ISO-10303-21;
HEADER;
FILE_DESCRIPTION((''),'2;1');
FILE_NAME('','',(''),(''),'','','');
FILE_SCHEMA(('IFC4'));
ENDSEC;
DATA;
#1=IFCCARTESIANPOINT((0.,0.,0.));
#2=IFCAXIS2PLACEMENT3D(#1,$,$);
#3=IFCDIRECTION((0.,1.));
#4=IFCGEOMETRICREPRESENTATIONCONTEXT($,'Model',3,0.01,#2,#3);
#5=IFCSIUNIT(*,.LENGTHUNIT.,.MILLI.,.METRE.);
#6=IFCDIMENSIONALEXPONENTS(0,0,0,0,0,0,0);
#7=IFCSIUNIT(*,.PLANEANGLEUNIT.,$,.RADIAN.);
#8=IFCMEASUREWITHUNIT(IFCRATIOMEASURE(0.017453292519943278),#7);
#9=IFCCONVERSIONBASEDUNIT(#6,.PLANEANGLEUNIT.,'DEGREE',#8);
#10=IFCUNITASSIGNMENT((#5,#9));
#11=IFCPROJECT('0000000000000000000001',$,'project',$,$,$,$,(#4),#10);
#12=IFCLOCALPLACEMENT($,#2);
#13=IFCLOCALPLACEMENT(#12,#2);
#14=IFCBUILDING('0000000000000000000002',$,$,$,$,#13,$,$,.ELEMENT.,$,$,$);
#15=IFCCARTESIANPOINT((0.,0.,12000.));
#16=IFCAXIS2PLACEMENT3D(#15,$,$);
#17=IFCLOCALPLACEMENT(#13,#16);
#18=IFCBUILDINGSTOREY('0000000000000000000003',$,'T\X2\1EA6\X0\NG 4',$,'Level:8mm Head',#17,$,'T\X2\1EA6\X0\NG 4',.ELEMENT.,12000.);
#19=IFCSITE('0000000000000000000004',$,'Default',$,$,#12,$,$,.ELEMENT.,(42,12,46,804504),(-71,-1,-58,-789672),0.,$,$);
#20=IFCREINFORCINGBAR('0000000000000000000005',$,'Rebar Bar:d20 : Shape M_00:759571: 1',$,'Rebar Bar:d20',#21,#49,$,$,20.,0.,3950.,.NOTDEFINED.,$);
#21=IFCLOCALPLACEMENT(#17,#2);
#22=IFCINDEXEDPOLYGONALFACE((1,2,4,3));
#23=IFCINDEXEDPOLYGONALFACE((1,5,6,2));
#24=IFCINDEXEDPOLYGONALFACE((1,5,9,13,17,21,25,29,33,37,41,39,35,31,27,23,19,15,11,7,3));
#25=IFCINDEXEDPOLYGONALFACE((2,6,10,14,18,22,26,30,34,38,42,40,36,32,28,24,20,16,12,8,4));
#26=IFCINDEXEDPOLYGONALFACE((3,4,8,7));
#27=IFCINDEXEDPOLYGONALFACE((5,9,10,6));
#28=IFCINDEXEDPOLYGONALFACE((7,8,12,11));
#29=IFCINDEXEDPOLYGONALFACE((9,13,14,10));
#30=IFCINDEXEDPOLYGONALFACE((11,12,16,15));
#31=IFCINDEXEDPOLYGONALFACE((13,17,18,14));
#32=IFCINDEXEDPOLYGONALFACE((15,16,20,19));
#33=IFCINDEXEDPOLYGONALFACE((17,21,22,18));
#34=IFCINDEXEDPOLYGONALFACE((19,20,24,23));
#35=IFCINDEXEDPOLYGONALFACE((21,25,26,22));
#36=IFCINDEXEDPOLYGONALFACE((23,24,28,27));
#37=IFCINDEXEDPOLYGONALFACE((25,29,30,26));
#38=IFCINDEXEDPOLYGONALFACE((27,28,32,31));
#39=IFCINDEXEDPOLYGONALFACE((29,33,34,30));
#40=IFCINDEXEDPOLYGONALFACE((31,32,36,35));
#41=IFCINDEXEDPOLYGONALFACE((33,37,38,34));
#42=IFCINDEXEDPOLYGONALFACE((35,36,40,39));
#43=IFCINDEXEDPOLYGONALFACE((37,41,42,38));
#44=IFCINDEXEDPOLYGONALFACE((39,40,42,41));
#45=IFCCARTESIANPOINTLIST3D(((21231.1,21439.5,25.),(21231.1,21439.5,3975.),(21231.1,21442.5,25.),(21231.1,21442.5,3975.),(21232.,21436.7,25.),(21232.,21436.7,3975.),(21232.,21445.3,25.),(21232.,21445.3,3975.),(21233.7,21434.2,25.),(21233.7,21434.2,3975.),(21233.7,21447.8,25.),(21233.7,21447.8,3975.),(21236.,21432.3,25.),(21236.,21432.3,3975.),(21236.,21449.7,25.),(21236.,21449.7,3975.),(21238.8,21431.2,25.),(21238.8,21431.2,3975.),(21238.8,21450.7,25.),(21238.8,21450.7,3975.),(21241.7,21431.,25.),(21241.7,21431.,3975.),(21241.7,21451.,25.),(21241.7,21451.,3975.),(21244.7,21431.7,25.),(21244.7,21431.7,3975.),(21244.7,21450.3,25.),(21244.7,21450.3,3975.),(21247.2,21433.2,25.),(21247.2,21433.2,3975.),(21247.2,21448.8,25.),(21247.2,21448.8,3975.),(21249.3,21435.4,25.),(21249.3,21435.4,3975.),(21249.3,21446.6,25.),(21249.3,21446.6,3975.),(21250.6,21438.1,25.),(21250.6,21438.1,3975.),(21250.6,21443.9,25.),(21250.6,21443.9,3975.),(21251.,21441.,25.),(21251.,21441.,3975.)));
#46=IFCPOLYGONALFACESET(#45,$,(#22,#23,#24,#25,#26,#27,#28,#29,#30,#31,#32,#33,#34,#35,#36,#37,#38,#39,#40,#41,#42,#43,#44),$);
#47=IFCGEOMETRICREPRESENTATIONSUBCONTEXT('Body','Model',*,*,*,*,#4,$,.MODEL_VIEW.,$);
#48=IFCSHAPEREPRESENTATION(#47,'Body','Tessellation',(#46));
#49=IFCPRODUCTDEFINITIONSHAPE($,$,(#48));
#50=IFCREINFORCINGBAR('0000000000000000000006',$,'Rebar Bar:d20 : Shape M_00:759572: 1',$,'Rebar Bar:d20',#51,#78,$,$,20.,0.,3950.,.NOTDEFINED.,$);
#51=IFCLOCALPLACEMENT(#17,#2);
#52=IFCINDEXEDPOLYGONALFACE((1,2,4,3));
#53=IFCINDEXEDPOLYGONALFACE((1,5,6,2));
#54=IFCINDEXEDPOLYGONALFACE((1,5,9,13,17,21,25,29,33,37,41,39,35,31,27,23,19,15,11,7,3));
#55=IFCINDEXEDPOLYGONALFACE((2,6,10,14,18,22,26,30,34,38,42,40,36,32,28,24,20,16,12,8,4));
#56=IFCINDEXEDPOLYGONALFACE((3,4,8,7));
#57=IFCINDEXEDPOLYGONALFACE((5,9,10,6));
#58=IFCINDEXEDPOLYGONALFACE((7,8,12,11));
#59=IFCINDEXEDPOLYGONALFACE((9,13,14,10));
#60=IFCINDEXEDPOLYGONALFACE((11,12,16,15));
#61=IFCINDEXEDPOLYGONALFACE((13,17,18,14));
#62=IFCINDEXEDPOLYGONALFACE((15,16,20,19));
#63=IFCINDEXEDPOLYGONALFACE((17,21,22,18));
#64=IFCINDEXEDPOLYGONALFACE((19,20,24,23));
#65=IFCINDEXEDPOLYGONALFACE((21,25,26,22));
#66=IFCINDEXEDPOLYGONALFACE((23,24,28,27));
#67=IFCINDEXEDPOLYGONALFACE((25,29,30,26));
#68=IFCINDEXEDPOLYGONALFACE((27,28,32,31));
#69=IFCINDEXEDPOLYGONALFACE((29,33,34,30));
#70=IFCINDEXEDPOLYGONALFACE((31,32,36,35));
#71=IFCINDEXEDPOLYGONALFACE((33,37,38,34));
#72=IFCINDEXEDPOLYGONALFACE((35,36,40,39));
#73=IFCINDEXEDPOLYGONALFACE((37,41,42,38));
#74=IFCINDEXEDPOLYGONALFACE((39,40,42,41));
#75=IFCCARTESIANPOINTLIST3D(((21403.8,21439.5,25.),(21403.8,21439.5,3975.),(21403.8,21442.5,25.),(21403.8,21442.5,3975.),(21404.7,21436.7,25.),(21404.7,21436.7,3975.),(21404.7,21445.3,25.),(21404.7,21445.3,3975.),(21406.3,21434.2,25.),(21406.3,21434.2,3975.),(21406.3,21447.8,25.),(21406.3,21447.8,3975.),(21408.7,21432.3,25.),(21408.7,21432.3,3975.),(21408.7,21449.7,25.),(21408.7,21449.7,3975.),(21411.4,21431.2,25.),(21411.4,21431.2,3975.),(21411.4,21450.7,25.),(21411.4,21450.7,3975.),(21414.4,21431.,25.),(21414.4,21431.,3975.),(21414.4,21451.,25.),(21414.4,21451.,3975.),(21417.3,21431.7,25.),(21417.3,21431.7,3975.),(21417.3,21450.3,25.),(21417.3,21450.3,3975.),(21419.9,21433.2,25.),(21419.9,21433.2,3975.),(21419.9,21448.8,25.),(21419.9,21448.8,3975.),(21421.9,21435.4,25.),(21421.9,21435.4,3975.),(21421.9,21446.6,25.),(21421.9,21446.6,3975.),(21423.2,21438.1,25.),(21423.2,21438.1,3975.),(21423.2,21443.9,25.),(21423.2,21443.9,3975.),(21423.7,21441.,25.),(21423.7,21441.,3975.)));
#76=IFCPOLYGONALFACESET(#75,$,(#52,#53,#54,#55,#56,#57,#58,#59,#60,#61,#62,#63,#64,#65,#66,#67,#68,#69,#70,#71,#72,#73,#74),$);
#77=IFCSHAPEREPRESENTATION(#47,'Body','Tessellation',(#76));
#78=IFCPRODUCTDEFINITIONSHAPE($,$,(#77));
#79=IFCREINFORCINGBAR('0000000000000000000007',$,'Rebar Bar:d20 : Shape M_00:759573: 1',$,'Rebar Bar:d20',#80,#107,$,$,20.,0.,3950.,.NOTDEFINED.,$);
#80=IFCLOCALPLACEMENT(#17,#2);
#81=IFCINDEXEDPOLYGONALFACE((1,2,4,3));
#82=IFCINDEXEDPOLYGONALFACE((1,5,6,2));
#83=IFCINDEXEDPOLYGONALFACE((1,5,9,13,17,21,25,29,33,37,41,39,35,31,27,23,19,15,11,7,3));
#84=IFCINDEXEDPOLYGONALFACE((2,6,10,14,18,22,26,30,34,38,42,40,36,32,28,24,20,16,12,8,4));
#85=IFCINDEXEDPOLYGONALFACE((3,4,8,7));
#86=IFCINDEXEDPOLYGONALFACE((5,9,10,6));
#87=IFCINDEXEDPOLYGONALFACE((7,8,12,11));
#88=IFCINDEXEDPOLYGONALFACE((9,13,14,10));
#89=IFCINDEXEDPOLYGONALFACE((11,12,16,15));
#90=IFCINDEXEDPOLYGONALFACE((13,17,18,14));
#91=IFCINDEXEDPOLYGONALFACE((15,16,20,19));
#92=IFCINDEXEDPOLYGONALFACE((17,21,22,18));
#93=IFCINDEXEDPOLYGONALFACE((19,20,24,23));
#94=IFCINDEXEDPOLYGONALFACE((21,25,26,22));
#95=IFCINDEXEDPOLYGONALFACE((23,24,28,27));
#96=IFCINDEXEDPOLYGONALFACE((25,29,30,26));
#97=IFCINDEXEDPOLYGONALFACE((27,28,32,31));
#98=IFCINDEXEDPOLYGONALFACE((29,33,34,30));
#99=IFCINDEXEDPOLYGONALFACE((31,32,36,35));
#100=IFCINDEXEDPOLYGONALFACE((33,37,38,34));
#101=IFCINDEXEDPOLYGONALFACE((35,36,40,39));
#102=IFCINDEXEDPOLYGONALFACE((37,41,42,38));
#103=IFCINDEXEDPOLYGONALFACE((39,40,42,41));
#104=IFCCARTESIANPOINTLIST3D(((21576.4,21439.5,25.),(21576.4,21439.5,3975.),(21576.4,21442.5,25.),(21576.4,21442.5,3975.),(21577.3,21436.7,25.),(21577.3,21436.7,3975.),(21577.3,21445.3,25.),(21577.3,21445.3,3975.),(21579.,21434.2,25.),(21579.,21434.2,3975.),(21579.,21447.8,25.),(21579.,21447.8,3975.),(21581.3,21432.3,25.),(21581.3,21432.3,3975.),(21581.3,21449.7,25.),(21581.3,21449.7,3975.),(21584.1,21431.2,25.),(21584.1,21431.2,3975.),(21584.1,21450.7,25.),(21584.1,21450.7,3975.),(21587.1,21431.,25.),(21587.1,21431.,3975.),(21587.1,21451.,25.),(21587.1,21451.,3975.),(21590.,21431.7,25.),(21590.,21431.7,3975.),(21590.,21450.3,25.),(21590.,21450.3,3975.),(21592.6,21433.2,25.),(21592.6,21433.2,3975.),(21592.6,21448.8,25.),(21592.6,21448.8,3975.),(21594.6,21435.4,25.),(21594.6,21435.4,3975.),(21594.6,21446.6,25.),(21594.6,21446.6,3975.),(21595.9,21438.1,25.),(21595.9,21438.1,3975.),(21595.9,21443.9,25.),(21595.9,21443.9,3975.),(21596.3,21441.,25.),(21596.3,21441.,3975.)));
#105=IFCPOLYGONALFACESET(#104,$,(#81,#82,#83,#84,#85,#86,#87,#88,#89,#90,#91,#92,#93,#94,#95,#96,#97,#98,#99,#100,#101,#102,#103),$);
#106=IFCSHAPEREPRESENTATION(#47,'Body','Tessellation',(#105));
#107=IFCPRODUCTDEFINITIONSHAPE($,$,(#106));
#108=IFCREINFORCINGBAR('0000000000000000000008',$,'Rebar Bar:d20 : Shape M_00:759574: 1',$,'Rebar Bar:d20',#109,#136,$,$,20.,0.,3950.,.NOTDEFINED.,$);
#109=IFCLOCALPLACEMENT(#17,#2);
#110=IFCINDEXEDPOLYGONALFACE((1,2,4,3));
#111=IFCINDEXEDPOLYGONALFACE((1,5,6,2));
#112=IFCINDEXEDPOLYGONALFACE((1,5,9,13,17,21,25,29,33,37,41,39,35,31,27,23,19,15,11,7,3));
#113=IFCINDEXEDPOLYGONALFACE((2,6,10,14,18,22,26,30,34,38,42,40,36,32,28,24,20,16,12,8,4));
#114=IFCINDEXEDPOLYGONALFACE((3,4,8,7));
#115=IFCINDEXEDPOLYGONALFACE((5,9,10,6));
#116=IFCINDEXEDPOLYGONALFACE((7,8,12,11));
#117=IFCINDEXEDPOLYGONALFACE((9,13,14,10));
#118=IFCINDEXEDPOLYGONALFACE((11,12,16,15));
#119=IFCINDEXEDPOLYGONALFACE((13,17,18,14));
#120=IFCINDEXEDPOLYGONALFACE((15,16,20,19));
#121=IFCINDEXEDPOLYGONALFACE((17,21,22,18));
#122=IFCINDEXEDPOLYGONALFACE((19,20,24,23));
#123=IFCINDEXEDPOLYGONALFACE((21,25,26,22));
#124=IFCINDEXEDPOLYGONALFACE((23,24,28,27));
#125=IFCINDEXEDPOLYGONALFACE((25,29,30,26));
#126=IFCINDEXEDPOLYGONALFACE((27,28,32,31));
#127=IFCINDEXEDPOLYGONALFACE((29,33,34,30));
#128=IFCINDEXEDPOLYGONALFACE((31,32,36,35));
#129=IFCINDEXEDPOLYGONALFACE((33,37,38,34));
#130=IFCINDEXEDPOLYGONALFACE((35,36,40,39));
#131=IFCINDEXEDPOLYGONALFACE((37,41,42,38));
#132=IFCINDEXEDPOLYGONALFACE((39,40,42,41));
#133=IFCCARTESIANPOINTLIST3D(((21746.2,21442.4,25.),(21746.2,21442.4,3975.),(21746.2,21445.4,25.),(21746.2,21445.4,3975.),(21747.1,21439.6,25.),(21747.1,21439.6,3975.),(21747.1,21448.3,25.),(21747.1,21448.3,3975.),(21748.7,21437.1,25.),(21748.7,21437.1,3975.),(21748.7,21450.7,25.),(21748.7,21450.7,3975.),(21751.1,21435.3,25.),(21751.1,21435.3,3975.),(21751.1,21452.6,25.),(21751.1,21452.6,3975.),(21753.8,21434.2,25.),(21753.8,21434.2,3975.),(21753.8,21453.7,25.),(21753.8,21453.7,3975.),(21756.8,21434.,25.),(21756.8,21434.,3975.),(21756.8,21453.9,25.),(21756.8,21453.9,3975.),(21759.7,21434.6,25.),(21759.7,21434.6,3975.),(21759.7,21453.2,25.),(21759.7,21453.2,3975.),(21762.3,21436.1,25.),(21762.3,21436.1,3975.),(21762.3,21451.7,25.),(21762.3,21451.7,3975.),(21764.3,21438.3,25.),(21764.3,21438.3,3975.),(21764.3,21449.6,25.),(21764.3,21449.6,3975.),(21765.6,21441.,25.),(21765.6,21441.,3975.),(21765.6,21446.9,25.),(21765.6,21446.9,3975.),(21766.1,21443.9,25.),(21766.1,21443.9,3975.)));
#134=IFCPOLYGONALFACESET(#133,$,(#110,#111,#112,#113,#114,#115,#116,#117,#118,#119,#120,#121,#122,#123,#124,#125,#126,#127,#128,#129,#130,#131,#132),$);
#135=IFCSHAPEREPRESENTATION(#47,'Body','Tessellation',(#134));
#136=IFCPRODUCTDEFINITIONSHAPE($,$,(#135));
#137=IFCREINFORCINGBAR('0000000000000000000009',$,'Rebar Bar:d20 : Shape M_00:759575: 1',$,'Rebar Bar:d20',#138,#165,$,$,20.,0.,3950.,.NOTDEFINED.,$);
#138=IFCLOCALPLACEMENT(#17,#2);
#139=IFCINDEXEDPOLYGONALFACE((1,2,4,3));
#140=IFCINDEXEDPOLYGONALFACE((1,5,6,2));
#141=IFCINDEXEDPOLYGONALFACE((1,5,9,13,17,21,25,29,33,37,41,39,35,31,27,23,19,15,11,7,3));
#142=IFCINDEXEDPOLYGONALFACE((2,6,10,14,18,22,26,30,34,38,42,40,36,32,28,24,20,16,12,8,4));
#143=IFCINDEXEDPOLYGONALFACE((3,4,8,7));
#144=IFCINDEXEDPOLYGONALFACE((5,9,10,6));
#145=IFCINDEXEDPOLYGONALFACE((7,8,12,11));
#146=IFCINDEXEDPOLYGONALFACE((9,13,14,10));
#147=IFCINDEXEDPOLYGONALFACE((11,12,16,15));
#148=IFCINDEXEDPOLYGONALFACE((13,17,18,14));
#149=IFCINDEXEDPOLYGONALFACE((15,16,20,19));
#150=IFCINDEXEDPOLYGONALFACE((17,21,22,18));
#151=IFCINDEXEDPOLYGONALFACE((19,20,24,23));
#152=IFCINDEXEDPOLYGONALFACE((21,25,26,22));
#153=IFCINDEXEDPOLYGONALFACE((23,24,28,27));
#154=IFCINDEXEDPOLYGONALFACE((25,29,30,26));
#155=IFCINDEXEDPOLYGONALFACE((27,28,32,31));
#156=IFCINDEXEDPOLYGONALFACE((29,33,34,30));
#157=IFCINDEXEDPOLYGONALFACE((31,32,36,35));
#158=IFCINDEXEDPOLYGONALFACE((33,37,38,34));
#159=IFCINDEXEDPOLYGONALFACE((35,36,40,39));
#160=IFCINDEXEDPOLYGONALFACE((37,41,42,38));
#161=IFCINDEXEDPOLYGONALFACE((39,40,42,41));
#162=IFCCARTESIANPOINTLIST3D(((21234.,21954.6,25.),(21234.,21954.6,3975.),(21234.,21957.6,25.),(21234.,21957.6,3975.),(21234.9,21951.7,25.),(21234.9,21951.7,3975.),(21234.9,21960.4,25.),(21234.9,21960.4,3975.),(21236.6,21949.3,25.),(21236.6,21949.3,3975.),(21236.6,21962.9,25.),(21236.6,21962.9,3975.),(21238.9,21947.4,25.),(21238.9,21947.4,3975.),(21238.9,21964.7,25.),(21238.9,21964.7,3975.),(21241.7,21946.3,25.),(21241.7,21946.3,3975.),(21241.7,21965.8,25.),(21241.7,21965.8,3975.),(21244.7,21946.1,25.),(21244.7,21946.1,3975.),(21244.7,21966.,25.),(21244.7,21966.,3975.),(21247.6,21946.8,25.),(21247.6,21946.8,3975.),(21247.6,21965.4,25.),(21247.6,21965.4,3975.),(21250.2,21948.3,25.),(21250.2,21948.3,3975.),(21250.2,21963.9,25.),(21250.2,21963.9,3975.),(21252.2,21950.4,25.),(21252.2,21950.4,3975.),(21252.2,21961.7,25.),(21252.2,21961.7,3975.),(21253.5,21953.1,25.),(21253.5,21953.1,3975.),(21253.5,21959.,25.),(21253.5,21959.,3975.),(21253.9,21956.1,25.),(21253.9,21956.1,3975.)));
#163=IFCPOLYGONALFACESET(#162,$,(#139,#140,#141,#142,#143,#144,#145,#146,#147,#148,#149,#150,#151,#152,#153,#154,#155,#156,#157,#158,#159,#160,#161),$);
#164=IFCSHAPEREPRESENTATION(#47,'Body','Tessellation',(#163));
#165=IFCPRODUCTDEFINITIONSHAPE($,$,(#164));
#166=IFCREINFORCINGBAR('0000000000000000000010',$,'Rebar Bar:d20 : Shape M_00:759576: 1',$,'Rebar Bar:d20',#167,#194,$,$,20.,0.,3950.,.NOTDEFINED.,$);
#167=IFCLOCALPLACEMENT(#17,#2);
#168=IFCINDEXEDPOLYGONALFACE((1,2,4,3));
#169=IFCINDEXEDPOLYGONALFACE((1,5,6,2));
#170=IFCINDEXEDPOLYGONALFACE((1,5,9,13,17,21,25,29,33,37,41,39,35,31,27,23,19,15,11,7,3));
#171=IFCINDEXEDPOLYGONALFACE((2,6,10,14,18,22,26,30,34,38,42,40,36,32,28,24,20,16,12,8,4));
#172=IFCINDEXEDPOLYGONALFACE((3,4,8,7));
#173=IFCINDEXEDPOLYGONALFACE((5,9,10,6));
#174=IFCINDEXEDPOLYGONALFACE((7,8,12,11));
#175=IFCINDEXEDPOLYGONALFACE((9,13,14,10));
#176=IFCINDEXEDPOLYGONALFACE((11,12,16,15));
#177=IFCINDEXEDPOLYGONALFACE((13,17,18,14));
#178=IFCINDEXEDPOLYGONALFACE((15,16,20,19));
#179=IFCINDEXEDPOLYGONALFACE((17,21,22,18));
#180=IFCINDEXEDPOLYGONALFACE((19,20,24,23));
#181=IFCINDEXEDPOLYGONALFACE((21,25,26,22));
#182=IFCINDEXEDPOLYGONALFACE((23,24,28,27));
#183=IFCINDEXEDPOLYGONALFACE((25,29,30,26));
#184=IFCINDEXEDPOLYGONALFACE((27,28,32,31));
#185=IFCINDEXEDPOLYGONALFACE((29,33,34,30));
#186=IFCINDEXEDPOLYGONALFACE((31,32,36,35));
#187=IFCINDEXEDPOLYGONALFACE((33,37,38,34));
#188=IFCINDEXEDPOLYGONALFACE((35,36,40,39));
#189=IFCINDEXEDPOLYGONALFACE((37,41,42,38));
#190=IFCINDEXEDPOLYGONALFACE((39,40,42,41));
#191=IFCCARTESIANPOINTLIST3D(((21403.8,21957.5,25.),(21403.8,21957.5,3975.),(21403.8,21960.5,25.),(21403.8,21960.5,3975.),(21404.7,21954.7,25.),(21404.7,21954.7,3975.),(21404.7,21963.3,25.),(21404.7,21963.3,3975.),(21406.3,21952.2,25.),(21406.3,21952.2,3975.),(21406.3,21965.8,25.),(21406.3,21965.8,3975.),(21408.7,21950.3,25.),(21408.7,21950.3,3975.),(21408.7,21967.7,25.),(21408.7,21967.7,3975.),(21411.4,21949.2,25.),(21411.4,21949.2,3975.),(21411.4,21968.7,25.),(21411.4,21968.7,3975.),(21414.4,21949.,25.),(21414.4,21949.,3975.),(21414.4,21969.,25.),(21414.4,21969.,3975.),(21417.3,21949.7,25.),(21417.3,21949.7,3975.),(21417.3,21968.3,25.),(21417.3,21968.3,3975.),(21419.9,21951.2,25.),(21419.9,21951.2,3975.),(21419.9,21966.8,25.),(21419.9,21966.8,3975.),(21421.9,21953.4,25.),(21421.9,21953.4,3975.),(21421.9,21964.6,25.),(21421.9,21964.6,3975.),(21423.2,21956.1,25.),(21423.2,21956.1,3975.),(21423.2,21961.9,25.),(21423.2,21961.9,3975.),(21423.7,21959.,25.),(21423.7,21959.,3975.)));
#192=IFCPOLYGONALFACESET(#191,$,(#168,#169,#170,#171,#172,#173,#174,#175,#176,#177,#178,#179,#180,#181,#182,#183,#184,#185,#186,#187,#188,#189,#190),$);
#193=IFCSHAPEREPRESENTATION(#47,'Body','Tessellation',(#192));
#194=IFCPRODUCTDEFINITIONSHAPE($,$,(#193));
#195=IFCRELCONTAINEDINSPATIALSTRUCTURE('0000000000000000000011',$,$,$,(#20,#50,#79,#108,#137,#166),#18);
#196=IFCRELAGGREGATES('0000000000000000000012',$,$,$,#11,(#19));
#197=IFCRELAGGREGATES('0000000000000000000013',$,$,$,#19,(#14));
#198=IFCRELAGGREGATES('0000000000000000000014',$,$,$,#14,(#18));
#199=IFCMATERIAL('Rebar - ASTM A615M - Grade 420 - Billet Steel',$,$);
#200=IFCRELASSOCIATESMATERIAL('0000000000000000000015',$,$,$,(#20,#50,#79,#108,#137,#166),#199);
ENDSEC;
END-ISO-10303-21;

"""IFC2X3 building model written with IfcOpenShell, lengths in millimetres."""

from ifc_helpers import new_model, entity, si_unit, converted_unit, direction, frame, origin, place, context, subcontext, project, spatial, material, element, save


model = new_model("IFC2X3")

# Units and contexts
model_context = context("Model", 3, precision=0.01, world=origin(), true_north=direction((0.0, 1.0)))
body_context = subcontext(model_context, "Body", "Model", "MODEL_VIEW")
ifc_project = project(units=[si_unit("LENGTHUNIT", "METRE", prefix="MILLI"), converted_unit("PLANEANGLEUNIT", "DEGREE", entity("IfcRatioMeasure", 0.017453292519943278), si_unit("PLANEANGLEUNIT", "RADIAN"), dimensions=[0, 0, 0, 0, 0, 0, 0])], contexts=[model_context])

# Site, building, storey
site_placement = place(None, origin())
site = spatial("IfcSite", under=ifc_project, at=site_placement, Name="Default", CompositionType="ELEMENT", RefLatitude=(42, 12, 46, 804504), RefLongitude=(-71, -1, -58, -789672), RefElevation=0.0)
building_placement = place(site_placement, origin())
building = spatial("IfcBuilding", under=site, at=building_placement, CompositionType="ELEMENT")
storey_placement = place(building_placement, frame((0.0, 0.0, 12000.0)))
storey = spatial("IfcBuildingStorey", under=building, at=storey_placement, Name="TẦNG 4", ObjectType="Level:8mm Head", LongName="TẦNG 4", CompositionType="ELEMENT", Elevation=12000.0)

# Reinforcing bars
ifc_material = material(Name="Rebar - ASTM A615M - Grade 420 - Billet Steel")
reinforcing_bar_1_placement = place(storey_placement, origin())
element("IfcReinforcingBar", 1, at=reinforcing_bar_1_placement, inside=storey, material=ifc_material, Name="Rebar Bar:d20 : Shape M_00:759571: 1", ObjectType="Rebar Bar:d20", BarLength=3950.0, BarRole="NOTDEFINED", CrossSectionArea=0.0, NominalDiameter=20.0, context=body_context, shape_type="AdvancedSweptSolid", body=[
    entity("IfcSweptDiskSolid", entity("IfcCompositeCurve", [entity("IfcCompositeCurveSegment", "CONTINUOUS", True, entity("IfcPolyline", [entity("IfcCartesianPoint", [21241.0, 21441.0, 25.0]), entity("IfcCartesianPoint", [21241.0, 21441.0, 3975.0])]))], False), 10.0, None, 0.0, 1.0),
])
reinforcing_bar_2_placement = place(storey_placement, origin())
element("IfcReinforcingBar", 2, at=reinforcing_bar_2_placement, inside=storey, material=ifc_material, Name="Rebar Bar:d20 : Shape M_00:759572: 1", ObjectType="Rebar Bar:d20", BarLength=3950.0, BarRole="NOTDEFINED", CrossSectionArea=0.0, NominalDiameter=20.0, context=body_context, shape_type="AdvancedSweptSolid", body=[
    entity("IfcSweptDiskSolid", entity("IfcCompositeCurve", [entity("IfcCompositeCurveSegment", "CONTINUOUS", True, entity("IfcPolyline", [entity("IfcCartesianPoint", [21413.7, 21441.0, 25.0]), entity("IfcCartesianPoint", [21413.7, 21441.0, 3975.0])]))], False), 10.0, None, 0.0, 1.0),
])
reinforcing_bar_3_placement = place(storey_placement, origin())
element("IfcReinforcingBar", 3, at=reinforcing_bar_3_placement, inside=storey, material=ifc_material, Name="Rebar Bar:d20 : Shape M_00:759573: 1", ObjectType="Rebar Bar:d20", BarLength=3950.0, BarRole="NOTDEFINED", CrossSectionArea=0.0, NominalDiameter=20.0, context=body_context, shape_type="AdvancedSweptSolid", body=[
    entity("IfcSweptDiskSolid", entity("IfcCompositeCurve", [entity("IfcCompositeCurveSegment", "CONTINUOUS", True, entity("IfcPolyline", [entity("IfcCartesianPoint", [21586.3, 21441.0, 25.0]), entity("IfcCartesianPoint", [21586.3, 21441.0, 3975.0])]))], False), 10.0, None, 0.0, 1.0),
])
reinforcing_bar_4_placement = place(storey_placement, origin())
element("IfcReinforcingBar", 4, at=reinforcing_bar_4_placement, inside=storey, material=ifc_material, Name="Rebar Bar:d20 : Shape M_00:759574: 1", ObjectType="Rebar Bar:d20", BarLength=3950.0, BarRole="NOTDEFINED", CrossSectionArea=0.0, NominalDiameter=20.0, context=body_context, shape_type="AdvancedSweptSolid", body=[
    entity("IfcSweptDiskSolid", entity("IfcCompositeCurve", [entity("IfcCompositeCurveSegment", "CONTINUOUS", True, entity("IfcPolyline", [entity("IfcCartesianPoint", [21756.1, 21443.9, 25.0]), entity("IfcCartesianPoint", [21756.1, 21443.9, 3975.0])]))], False), 10.0, None, 0.0, 1.0),
])
reinforcing_bar_5_placement = place(storey_placement, origin())
element("IfcReinforcingBar", 5, at=reinforcing_bar_5_placement, inside=storey, material=ifc_material, Name="Rebar Bar:d20 : Shape M_00:759575: 1", ObjectType="Rebar Bar:d20", BarLength=3950.0, BarRole="NOTDEFINED", CrossSectionArea=0.0, NominalDiameter=20.0, context=body_context, shape_type="AdvancedSweptSolid", body=[
    entity("IfcSweptDiskSolid", entity("IfcCompositeCurve", [entity("IfcCompositeCurveSegment", "CONTINUOUS", True, entity("IfcPolyline", [entity("IfcCartesianPoint", [21243.9, 21956.1, 25.0]), entity("IfcCartesianPoint", [21243.9, 21956.1, 3975.0])]))], False), 10.0, None, 0.0, 1.0),
])
reinforcing_bar_6_placement = place(storey_placement, origin())
element("IfcReinforcingBar", 6, at=reinforcing_bar_6_placement, inside=storey, material=ifc_material, Name="Rebar Bar:d20 : Shape M_00:759576: 1", ObjectType="Rebar Bar:d20", BarLength=3950.0, BarRole="NOTDEFINED", CrossSectionArea=0.0, NominalDiameter=20.0, context=body_context, shape_type="AdvancedSweptSolid", body=[
    entity("IfcSweptDiskSolid", entity("IfcCompositeCurve", [entity("IfcCompositeCurveSegment", "CONTINUOUS", True, entity("IfcPolyline", [entity("IfcCartesianPoint", [21413.7, 21959.0, 25.0]), entity("IfcCartesianPoint", [21413.7, 21959.0, 3975.0])]))], False), 10.0, None, 0.0, 1.0),
])

save(model, "model.ifc")
